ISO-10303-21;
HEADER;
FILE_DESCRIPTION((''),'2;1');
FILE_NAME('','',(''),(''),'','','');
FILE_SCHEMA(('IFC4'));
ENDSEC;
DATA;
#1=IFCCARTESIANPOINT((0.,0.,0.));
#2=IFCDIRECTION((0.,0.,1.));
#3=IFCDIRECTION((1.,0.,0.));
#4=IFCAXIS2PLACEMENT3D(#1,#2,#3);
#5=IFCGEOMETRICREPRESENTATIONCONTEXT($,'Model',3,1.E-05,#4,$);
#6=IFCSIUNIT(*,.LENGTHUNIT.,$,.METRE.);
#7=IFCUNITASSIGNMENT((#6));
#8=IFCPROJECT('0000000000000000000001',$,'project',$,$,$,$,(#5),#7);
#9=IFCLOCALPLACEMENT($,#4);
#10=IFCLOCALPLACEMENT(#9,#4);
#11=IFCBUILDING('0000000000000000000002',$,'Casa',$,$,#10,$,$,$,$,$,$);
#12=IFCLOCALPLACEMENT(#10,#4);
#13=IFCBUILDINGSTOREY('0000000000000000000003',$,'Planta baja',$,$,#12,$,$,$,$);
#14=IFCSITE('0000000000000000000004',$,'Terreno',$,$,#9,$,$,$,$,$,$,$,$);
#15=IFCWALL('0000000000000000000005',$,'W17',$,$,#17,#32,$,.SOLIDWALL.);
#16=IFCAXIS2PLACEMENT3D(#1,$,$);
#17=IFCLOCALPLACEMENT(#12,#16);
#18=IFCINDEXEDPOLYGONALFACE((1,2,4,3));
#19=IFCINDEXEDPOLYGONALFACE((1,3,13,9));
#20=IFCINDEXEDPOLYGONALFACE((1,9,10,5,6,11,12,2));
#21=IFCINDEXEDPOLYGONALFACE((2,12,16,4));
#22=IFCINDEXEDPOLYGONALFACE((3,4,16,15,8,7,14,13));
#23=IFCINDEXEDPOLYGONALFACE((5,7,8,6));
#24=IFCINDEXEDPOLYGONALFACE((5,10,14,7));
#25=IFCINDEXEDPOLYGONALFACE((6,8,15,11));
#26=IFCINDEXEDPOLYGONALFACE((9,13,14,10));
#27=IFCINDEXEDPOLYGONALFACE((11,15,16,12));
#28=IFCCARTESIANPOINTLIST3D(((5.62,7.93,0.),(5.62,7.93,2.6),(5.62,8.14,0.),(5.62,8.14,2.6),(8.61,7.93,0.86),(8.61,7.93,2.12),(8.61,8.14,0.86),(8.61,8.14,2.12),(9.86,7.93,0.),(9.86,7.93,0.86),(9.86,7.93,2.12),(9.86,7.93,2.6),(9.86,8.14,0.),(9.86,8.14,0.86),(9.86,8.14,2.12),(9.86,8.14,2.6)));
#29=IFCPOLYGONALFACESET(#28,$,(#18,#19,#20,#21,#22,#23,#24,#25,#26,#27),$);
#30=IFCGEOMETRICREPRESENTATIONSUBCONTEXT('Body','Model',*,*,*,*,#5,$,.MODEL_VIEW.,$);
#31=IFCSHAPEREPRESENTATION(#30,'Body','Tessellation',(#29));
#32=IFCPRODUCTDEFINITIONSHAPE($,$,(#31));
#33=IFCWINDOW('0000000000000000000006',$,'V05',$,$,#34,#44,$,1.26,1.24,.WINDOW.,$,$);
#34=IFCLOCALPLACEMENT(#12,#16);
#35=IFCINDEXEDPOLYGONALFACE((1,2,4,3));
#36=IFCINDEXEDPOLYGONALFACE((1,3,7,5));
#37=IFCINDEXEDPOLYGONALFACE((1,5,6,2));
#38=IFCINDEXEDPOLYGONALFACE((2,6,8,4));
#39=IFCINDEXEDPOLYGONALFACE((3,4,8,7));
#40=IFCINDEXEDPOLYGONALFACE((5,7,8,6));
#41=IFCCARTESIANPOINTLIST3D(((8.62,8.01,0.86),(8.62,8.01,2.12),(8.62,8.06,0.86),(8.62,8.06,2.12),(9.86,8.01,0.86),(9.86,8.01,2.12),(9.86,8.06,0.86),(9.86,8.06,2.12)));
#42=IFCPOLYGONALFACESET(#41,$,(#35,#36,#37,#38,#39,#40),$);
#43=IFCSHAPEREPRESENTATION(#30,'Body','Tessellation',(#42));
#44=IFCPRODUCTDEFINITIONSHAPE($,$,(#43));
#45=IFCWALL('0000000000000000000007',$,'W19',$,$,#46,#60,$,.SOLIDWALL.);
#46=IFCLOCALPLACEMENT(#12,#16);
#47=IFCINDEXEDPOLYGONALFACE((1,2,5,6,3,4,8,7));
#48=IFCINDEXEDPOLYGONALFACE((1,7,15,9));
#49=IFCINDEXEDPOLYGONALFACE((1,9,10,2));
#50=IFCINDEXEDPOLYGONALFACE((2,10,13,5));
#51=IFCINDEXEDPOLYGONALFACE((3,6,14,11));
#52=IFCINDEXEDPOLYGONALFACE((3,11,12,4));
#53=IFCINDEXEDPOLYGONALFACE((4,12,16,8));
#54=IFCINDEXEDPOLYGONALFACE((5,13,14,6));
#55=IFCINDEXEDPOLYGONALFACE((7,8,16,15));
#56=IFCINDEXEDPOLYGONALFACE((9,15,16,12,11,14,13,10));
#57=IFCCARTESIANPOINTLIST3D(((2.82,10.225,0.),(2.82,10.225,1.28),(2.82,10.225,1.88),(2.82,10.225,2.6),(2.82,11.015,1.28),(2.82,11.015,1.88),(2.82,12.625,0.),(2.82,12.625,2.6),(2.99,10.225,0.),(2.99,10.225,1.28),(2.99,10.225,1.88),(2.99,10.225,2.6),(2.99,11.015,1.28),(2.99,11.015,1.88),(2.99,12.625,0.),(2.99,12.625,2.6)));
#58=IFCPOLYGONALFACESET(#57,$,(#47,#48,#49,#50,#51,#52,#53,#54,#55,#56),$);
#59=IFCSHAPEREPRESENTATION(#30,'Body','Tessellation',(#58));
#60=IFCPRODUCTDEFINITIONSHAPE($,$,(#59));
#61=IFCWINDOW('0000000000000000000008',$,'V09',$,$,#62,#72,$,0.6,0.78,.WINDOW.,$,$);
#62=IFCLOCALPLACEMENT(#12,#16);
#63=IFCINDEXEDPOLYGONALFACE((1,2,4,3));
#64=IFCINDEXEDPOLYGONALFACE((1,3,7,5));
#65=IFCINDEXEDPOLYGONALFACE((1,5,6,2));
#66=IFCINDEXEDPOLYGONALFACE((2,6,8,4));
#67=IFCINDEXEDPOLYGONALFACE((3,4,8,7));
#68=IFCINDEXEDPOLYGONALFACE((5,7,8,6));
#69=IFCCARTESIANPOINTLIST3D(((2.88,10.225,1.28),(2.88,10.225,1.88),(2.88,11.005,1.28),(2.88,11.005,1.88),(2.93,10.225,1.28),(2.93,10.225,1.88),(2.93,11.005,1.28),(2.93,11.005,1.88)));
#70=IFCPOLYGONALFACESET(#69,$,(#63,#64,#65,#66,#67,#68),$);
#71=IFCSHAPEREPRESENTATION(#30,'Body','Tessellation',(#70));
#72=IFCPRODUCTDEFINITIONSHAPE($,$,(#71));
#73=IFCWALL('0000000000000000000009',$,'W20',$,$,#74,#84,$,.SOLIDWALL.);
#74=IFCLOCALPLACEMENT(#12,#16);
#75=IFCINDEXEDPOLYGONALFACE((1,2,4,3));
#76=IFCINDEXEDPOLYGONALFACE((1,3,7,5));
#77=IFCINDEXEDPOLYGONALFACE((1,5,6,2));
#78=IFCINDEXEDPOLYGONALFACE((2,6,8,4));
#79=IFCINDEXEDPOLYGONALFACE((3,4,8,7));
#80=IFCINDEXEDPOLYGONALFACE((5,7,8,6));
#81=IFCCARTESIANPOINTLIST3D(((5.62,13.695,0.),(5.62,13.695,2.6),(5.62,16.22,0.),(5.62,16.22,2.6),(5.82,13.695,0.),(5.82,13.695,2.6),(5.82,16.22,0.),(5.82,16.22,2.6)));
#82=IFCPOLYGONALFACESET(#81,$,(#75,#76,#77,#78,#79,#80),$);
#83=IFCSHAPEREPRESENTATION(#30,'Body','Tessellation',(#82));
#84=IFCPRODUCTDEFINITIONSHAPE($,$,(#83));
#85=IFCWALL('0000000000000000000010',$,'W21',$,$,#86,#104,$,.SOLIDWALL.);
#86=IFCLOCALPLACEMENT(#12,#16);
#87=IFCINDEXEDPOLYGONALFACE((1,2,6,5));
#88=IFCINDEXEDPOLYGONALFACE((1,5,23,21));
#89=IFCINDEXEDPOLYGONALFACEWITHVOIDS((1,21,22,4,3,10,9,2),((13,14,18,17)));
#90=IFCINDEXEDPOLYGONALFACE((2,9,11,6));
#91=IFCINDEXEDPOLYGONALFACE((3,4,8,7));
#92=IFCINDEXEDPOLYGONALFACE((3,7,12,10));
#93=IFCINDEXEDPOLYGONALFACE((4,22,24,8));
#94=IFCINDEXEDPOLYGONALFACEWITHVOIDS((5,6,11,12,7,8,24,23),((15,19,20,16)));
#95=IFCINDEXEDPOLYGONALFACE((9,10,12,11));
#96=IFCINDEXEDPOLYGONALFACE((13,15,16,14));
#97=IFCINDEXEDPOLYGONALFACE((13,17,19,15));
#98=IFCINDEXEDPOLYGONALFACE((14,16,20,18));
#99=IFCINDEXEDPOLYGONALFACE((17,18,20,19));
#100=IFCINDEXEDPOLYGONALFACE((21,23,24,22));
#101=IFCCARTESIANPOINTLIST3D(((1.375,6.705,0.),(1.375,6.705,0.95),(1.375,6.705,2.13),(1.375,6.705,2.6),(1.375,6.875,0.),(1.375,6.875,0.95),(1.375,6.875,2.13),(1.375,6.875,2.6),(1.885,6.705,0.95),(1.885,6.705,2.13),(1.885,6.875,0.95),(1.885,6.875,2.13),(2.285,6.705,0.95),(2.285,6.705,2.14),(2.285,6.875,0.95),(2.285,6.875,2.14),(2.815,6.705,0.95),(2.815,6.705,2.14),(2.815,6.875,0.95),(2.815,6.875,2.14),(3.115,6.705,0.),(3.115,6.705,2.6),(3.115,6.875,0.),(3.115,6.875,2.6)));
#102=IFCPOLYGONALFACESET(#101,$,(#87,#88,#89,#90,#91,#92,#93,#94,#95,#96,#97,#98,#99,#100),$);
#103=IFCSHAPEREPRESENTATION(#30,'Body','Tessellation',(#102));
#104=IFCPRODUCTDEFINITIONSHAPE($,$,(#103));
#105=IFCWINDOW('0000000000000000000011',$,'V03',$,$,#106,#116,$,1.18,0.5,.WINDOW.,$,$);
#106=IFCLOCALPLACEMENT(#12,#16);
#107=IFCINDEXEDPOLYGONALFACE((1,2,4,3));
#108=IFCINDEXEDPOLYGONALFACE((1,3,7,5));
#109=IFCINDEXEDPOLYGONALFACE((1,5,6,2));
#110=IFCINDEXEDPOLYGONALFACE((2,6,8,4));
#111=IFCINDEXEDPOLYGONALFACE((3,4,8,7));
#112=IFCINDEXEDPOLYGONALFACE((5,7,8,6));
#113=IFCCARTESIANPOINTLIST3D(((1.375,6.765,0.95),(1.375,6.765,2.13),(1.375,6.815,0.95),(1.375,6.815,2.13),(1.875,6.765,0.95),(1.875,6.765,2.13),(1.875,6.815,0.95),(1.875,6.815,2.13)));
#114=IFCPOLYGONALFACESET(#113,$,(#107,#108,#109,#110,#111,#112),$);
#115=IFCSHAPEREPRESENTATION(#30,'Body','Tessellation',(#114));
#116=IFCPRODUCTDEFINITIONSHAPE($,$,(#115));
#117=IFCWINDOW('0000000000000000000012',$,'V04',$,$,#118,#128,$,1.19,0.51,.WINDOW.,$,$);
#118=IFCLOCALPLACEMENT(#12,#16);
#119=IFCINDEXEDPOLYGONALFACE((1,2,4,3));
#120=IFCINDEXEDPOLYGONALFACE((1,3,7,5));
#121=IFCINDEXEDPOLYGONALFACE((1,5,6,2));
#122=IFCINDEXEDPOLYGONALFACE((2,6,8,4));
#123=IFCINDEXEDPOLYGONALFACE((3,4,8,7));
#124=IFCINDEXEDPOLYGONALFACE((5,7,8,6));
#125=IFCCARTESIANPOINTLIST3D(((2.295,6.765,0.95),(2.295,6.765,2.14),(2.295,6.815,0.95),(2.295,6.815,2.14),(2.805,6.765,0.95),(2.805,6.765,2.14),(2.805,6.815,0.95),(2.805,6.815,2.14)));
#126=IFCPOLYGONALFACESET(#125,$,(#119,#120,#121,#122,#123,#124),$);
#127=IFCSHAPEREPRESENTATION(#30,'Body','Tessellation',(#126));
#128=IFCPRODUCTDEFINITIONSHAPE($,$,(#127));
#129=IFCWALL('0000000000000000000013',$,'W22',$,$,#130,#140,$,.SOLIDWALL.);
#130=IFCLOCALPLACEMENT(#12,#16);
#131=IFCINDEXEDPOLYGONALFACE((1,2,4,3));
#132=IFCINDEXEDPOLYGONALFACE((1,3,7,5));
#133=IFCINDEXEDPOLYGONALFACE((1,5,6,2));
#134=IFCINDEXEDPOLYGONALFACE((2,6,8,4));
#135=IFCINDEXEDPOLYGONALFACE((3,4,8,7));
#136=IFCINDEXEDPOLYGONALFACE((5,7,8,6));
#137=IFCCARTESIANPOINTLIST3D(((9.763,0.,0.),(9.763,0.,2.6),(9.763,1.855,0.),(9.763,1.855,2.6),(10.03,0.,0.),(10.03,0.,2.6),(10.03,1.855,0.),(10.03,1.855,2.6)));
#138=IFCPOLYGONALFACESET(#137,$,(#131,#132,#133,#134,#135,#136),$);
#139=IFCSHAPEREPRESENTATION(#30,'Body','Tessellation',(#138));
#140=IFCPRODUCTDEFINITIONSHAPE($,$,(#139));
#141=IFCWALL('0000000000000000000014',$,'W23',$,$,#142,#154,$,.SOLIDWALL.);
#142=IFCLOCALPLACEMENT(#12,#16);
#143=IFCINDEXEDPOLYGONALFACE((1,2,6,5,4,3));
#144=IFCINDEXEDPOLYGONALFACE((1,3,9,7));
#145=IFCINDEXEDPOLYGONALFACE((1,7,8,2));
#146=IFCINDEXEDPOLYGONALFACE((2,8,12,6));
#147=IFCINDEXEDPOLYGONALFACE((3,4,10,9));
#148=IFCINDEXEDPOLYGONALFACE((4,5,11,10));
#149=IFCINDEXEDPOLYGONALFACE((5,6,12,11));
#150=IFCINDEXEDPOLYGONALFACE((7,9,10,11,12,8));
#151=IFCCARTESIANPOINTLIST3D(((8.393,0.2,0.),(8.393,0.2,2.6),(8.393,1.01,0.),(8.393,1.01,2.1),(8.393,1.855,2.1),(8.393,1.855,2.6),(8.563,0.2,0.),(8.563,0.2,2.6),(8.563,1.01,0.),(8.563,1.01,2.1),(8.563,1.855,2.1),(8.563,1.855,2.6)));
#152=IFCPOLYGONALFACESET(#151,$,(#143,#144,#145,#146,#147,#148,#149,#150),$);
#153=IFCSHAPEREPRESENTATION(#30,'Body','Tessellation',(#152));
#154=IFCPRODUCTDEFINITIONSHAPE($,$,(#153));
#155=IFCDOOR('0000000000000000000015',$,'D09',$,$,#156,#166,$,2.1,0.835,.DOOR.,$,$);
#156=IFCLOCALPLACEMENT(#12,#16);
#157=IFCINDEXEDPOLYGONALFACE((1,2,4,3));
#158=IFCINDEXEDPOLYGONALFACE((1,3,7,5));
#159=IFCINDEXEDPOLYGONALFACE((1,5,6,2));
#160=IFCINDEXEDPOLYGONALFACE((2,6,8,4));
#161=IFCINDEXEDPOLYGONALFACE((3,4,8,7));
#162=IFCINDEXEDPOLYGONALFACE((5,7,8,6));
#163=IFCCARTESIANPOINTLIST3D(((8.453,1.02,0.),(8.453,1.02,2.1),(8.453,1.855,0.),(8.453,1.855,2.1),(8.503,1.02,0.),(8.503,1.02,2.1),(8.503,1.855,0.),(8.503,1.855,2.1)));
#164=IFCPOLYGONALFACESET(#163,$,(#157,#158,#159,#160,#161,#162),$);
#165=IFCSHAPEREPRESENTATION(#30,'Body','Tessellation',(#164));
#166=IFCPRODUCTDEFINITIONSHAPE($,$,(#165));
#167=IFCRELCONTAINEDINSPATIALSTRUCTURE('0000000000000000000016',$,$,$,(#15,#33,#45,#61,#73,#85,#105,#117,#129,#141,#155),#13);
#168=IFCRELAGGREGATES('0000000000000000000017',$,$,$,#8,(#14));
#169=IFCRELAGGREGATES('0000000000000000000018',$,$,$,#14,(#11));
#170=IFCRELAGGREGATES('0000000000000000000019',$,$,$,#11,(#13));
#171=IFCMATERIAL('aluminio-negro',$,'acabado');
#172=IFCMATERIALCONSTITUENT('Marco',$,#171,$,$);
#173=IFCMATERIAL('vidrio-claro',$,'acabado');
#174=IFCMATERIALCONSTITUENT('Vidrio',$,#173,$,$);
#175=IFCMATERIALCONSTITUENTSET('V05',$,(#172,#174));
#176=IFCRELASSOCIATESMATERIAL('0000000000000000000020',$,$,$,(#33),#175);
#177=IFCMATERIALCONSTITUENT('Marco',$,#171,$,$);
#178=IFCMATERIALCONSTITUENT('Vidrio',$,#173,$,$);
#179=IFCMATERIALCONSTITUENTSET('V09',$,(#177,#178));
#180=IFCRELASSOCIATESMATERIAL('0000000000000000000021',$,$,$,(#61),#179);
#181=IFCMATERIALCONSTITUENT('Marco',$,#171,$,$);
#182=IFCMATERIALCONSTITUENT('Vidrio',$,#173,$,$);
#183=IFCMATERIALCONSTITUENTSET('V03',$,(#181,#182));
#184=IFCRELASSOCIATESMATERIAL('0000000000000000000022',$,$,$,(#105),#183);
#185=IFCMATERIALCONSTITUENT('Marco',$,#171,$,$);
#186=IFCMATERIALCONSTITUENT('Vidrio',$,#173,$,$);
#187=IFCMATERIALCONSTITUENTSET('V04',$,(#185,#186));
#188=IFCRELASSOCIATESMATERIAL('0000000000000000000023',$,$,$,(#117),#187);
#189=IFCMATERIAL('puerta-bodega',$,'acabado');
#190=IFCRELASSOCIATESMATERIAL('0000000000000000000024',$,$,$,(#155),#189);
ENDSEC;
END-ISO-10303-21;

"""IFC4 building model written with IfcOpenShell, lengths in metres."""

from ifc_helpers import new_model, si_unit, frame, origin_with_axes, place, context, subcontext, project, spatial, line, indexed_curve, outline, extrude, material, constituent, constituent_set, element, fill, save


model = new_model("IFC4")

# Units and contexts
model_context = context("Model", 3, precision=1e-05, world=origin_with_axes())
body_context = subcontext(model_context, "Body", "Model", "MODEL_VIEW")
ifc_project = project(units=[si_unit("LENGTHUNIT", "METRE")], contexts=[model_context])

# Site, building, storey
site_placement = place(None, origin_with_axes())
site = spatial("IfcSite", under=ifc_project, at=site_placement, Name="Terreno")
building_placement = place(site_placement, origin_with_axes())
building = spatial("IfcBuilding", under=site, at=building_placement, Name="Casa")
storey_placement = place(building_placement, origin_with_axes())
storey = spatial("IfcBuildingStorey", under=building, at=storey_placement, Name="Planta baja")

# Walls, openings, windows
wall_1_placement = place(storey_placement, origin_with_axes())
wall_1 = element("IfcWall", 1, at=wall_1_placement, inside=storey, Name="W17", PredefinedType="SOLIDWALL", context=body_context, shape_type="SweptSolid", body=[
    extrude(outline(indexed_curve([(5.62, 7.93), (5.62, 8.14), (9.86, 8.14), (9.86, 7.93)], segments=[line(1, 2, 3, 4, 1)])), origin_with_axes(), (0.0, 0.0, 1.0), 2.6),
])
opening_1_placement = place(wall_1_placement, origin_with_axes())
opening_1 = element("IfcOpeningElement", 2, at=opening_1_placement, cuts=wall_1, PredefinedType="OPENING", context=body_context, shape_type="SweptSolid", body=[
    extrude(outline(indexed_curve([(8.61, 7.92), (9.87, 7.92), (9.87, 8.15), (8.61, 8.15)], segments=[line(1, 2, 3, 4, 1)])), frame((0.0, 0.0, 0.86), z_axis=(0.0, 0.0, 1.0), x_axis=(1.0, 0.0, 0.0)), (0.0, 0.0, 1.0), 1.26),
])
ifc_material_1 = material(Name="aluminio-negro", Category="acabado")
ifc_constituent_1 = constituent(ifc_material_1, Name="Marco")
ifc_material_2 = material(Name="vidrio-claro", Category="acabado")
ifc_constituent_2 = constituent(ifc_material_2, Name="Vidrio")
ifc_constituent_set_1 = constituent_set(constituents=[ifc_constituent_1, ifc_constituent_2], Name="V05")
window_1_placement = place(opening_1_placement, origin_with_axes())
window_1 = element("IfcWindow", 3, at=window_1_placement, inside=storey, material=ifc_constituent_set_1, Name="V05", OverallHeight=1.26, OverallWidth=1.24, PredefinedType="WINDOW", context=body_context, shape_type="SweptSolid", body=[
    extrude(outline(indexed_curve([(8.62, 8.01), (9.86, 8.01), (9.86, 8.06), (8.62, 8.06)], segments=[line(1, 2, 3, 4, 1)])), frame((0.0, 0.0, 0.86), z_axis=(0.0, 0.0, 1.0), x_axis=(1.0, 0.0, 0.0)), (0.0, 0.0, 1.0), 1.26),
])
fill(opening_1, window_1)
wall_2_placement = place(storey_placement, origin_with_axes())
wall_2 = element("IfcWall", 4, at=wall_2_placement, inside=storey, Name="W19", PredefinedType="SOLIDWALL", context=body_context, shape_type="SweptSolid", body=[
    extrude(outline(indexed_curve([(2.99, 10.225), (2.82, 10.225), (2.82, 12.625), (2.99, 12.625)], segments=[line(1, 2, 3, 4, 1)])), origin_with_axes(), (0.0, 0.0, 1.0), 2.6),
])
opening_2_placement = place(wall_2_placement, origin_with_axes())
opening_2 = element("IfcOpeningElement", 5, at=opening_2_placement, cuts=wall_2, PredefinedType="OPENING", context=body_context, shape_type="SweptSolid", body=[
    extrude(outline(indexed_curve([(2.81, 10.215), (2.81, 11.015), (3.0, 11.015), (3.0, 10.215)], segments=[line(1, 2, 3, 4, 1)])), frame((0.0, 0.0, 1.28), z_axis=(0.0, 0.0, 1.0), x_axis=(1.0, 0.0, 0.0)), (0.0, 0.0, 1.0), 0.6),
])
ifc_constituent_3 = constituent(ifc_material_1, Name="Marco")
ifc_constituent_4 = constituent(ifc_material_2, Name="Vidrio")
ifc_constituent_set_2 = constituent_set(constituents=[ifc_constituent_3, ifc_constituent_4], Name="V09")
window_2_placement = place(opening_2_placement, origin_with_axes())
window_2 = element("IfcWindow", 6, at=window_2_placement, inside=storey, material=ifc_constituent_set_2, Name="V09", OverallHeight=0.6, OverallWidth=0.78, PredefinedType="WINDOW", context=body_context, shape_type="SweptSolid", body=[
    extrude(outline(indexed_curve([(2.88, 10.225), (2.88, 11.005), (2.93, 11.005), (2.93, 10.225)], segments=[line(1, 2, 3, 4, 1)])), frame((0.0, 0.0, 1.28), z_axis=(0.0, 0.0, 1.0), x_axis=(1.0, 0.0, 0.0)), (0.0, 0.0, 1.0), 0.6),
])
fill(opening_2, window_2)

# Wall
wall_3_placement = place(storey_placement, origin_with_axes())
element("IfcWall", 7, at=wall_3_placement, inside=storey, Name="W20", PredefinedType="SOLIDWALL", context=body_context, shape_type="SweptSolid", body=[
    extrude(outline(indexed_curve([(5.62, 16.22), (5.82, 16.22), (5.82, 13.695), (5.62, 13.695)], segments=[line(1, 2, 3, 4, 1)])), origin_with_axes(), (0.0, 0.0, 1.0), 2.6),
])

# Wall, openings, windows
wall_4_placement = place(storey_placement, origin_with_axes())
wall_4 = element("IfcWall", 8, at=wall_4_placement, inside=storey, Name="W21", PredefinedType="SOLIDWALL", context=body_context, shape_type="SweptSolid", body=[
    extrude(outline(indexed_curve([(1.375, 6.705), (1.375, 6.875), (3.115, 6.875), (3.115, 6.705)], segments=[line(1, 2, 3, 4, 1)])), origin_with_axes(), (0.0, 0.0, 1.0), 2.6),
])
opening_3_placement = place(wall_4_placement, origin_with_axes())
opening_3 = element("IfcOpeningElement", 9, at=opening_3_placement, cuts=wall_4, PredefinedType="OPENING", context=body_context, shape_type="SweptSolid", body=[
    extrude(outline(indexed_curve([(1.365, 6.695), (1.885, 6.695), (1.885, 6.885), (1.365, 6.885)], segments=[line(1, 2, 3, 4, 1)])), frame((0.0, 0.0, 0.95), z_axis=(0.0, 0.0, 1.0), x_axis=(1.0, 0.0, 0.0)), (0.0, 0.0, 1.0), 1.18),
])
opening_4_placement = place(wall_4_placement, origin_with_axes())
opening_4 = element("IfcOpeningElement", 10, at=opening_4_placement, cuts=wall_4, PredefinedType="OPENING", context=body_context, shape_type="SweptSolid", body=[
    extrude(outline(indexed_curve([(2.285, 6.695), (2.815, 6.695), (2.815, 6.885), (2.285, 6.885)], segments=[line(1, 2, 3, 4, 1)])), frame((0.0, 0.0, 0.95), z_axis=(0.0, 0.0, 1.0), x_axis=(1.0, 0.0, 0.0)), (0.0, 0.0, 1.0), 1.19),
])
ifc_constituent_5 = constituent(ifc_material_1, Name="Marco")
ifc_constituent_6 = constituent(ifc_material_2, Name="Vidrio")
ifc_constituent_set_3 = constituent_set(constituents=[ifc_constituent_5, ifc_constituent_6], Name="V03")
window_3_placement = place(opening_3_placement, origin_with_axes())
window_3 = element("IfcWindow", 11, at=window_3_placement, inside=storey, material=ifc_constituent_set_3, Name="V03", OverallHeight=1.18, OverallWidth=0.5, PredefinedType="WINDOW", context=body_context, shape_type="SweptSolid", body=[
    extrude(outline(indexed_curve([(1.375, 6.765), (1.875, 6.765), (1.875, 6.815), (1.375, 6.815)], segments=[line(1, 2, 3, 4, 1)])), frame((0.0, 0.0, 0.95), z_axis=(0.0, 0.0, 1.0), x_axis=(1.0, 0.0, 0.0)), (0.0, 0.0, 1.0), 1.18),
])
fill(opening_3, window_3)
ifc_constituent_7 = constituent(ifc_material_1, Name="Marco")
ifc_constituent_8 = constituent(ifc_material_2, Name="Vidrio")
ifc_constituent_set_4 = constituent_set(constituents=[ifc_constituent_7, ifc_constituent_8], Name="V04")
window_4_placement = place(opening_4_placement, origin_with_axes())
window_4 = element("IfcWindow", 12, at=window_4_placement, inside=storey, material=ifc_constituent_set_4, Name="V04", OverallHeight=1.19, OverallWidth=0.51, PredefinedType="WINDOW", context=body_context, shape_type="SweptSolid", body=[
    extrude(outline(indexed_curve([(2.295, 6.765), (2.805, 6.765), (2.805, 6.815), (2.295, 6.815)], segments=[line(1, 2, 3, 4, 1)])), frame((0.0, 0.0, 0.95), z_axis=(0.0, 0.0, 1.0), x_axis=(1.0, 0.0, 0.0)), (0.0, 0.0, 1.0), 1.19),
])
fill(opening_4, window_4)

# Wall
wall_5_placement = place(storey_placement, origin_with_axes())
element("IfcWall", 13, at=wall_5_placement, inside=storey, Name="W22", PredefinedType="SOLIDWALL", context=body_context, shape_type="SweptSolid", body=[
    extrude(outline(indexed_curve([(9.763, 0.0), (9.763, 1.855), (10.03, 1.855), (10.03, 0.0)], segments=[line(1, 2, 3, 4, 1)])), origin_with_axes(), (0.0, 0.0, 1.0), 2.6),
])

# Wall, opening, door
wall_6_placement = place(storey_placement, origin_with_axes())
wall_6 = element("IfcWall", 14, at=wall_6_placement, inside=storey, Name="W23", PredefinedType="SOLIDWALL", context=body_context, shape_type="SweptSolid", body=[
    extrude(outline(indexed_curve([(8.393, 0.2), (8.393, 1.855), (8.563, 1.855), (8.563, 0.2)], segments=[line(1, 2, 3, 4, 1)])), origin_with_axes(), (0.0, 0.0, 1.0), 2.6),
])
opening_5_placement = place(wall_6_placement, origin_with_axes())
opening_5 = element("IfcOpeningElement", 15, at=opening_5_placement, cuts=wall_6, PredefinedType="OPENING", context=body_context, shape_type="SweptSolid", body=[
    extrude(outline(indexed_curve([(8.383, 1.01), (8.383, 1.865), (8.573, 1.865), (8.573, 1.01)], segments=[line(1, 2, 3, 4, 1)])), origin_with_axes(), (0.0, 0.0, 1.0), 2.1),
])
ifc_material_3 = material(Name="puerta-bodega", Category="acabado")
door_placement = place(opening_5_placement, origin_with_axes())
door = element("IfcDoor", 16, at=door_placement, inside=storey, material=ifc_material_3, Name="D09", OverallHeight=2.1, OverallWidth=0.835, PredefinedType="DOOR", context=body_context, shape_type="SweptSolid", body=[
    extrude(outline(indexed_curve([(8.453, 1.02), (8.453, 1.855), (8.503, 1.855), (8.503, 1.02)], segments=[line(1, 2, 3, 4, 1)])), origin_with_axes(), (0.0, 0.0, 1.0), 2.1),
])
fill(opening_5, door)

save(model, "model.ifc")
